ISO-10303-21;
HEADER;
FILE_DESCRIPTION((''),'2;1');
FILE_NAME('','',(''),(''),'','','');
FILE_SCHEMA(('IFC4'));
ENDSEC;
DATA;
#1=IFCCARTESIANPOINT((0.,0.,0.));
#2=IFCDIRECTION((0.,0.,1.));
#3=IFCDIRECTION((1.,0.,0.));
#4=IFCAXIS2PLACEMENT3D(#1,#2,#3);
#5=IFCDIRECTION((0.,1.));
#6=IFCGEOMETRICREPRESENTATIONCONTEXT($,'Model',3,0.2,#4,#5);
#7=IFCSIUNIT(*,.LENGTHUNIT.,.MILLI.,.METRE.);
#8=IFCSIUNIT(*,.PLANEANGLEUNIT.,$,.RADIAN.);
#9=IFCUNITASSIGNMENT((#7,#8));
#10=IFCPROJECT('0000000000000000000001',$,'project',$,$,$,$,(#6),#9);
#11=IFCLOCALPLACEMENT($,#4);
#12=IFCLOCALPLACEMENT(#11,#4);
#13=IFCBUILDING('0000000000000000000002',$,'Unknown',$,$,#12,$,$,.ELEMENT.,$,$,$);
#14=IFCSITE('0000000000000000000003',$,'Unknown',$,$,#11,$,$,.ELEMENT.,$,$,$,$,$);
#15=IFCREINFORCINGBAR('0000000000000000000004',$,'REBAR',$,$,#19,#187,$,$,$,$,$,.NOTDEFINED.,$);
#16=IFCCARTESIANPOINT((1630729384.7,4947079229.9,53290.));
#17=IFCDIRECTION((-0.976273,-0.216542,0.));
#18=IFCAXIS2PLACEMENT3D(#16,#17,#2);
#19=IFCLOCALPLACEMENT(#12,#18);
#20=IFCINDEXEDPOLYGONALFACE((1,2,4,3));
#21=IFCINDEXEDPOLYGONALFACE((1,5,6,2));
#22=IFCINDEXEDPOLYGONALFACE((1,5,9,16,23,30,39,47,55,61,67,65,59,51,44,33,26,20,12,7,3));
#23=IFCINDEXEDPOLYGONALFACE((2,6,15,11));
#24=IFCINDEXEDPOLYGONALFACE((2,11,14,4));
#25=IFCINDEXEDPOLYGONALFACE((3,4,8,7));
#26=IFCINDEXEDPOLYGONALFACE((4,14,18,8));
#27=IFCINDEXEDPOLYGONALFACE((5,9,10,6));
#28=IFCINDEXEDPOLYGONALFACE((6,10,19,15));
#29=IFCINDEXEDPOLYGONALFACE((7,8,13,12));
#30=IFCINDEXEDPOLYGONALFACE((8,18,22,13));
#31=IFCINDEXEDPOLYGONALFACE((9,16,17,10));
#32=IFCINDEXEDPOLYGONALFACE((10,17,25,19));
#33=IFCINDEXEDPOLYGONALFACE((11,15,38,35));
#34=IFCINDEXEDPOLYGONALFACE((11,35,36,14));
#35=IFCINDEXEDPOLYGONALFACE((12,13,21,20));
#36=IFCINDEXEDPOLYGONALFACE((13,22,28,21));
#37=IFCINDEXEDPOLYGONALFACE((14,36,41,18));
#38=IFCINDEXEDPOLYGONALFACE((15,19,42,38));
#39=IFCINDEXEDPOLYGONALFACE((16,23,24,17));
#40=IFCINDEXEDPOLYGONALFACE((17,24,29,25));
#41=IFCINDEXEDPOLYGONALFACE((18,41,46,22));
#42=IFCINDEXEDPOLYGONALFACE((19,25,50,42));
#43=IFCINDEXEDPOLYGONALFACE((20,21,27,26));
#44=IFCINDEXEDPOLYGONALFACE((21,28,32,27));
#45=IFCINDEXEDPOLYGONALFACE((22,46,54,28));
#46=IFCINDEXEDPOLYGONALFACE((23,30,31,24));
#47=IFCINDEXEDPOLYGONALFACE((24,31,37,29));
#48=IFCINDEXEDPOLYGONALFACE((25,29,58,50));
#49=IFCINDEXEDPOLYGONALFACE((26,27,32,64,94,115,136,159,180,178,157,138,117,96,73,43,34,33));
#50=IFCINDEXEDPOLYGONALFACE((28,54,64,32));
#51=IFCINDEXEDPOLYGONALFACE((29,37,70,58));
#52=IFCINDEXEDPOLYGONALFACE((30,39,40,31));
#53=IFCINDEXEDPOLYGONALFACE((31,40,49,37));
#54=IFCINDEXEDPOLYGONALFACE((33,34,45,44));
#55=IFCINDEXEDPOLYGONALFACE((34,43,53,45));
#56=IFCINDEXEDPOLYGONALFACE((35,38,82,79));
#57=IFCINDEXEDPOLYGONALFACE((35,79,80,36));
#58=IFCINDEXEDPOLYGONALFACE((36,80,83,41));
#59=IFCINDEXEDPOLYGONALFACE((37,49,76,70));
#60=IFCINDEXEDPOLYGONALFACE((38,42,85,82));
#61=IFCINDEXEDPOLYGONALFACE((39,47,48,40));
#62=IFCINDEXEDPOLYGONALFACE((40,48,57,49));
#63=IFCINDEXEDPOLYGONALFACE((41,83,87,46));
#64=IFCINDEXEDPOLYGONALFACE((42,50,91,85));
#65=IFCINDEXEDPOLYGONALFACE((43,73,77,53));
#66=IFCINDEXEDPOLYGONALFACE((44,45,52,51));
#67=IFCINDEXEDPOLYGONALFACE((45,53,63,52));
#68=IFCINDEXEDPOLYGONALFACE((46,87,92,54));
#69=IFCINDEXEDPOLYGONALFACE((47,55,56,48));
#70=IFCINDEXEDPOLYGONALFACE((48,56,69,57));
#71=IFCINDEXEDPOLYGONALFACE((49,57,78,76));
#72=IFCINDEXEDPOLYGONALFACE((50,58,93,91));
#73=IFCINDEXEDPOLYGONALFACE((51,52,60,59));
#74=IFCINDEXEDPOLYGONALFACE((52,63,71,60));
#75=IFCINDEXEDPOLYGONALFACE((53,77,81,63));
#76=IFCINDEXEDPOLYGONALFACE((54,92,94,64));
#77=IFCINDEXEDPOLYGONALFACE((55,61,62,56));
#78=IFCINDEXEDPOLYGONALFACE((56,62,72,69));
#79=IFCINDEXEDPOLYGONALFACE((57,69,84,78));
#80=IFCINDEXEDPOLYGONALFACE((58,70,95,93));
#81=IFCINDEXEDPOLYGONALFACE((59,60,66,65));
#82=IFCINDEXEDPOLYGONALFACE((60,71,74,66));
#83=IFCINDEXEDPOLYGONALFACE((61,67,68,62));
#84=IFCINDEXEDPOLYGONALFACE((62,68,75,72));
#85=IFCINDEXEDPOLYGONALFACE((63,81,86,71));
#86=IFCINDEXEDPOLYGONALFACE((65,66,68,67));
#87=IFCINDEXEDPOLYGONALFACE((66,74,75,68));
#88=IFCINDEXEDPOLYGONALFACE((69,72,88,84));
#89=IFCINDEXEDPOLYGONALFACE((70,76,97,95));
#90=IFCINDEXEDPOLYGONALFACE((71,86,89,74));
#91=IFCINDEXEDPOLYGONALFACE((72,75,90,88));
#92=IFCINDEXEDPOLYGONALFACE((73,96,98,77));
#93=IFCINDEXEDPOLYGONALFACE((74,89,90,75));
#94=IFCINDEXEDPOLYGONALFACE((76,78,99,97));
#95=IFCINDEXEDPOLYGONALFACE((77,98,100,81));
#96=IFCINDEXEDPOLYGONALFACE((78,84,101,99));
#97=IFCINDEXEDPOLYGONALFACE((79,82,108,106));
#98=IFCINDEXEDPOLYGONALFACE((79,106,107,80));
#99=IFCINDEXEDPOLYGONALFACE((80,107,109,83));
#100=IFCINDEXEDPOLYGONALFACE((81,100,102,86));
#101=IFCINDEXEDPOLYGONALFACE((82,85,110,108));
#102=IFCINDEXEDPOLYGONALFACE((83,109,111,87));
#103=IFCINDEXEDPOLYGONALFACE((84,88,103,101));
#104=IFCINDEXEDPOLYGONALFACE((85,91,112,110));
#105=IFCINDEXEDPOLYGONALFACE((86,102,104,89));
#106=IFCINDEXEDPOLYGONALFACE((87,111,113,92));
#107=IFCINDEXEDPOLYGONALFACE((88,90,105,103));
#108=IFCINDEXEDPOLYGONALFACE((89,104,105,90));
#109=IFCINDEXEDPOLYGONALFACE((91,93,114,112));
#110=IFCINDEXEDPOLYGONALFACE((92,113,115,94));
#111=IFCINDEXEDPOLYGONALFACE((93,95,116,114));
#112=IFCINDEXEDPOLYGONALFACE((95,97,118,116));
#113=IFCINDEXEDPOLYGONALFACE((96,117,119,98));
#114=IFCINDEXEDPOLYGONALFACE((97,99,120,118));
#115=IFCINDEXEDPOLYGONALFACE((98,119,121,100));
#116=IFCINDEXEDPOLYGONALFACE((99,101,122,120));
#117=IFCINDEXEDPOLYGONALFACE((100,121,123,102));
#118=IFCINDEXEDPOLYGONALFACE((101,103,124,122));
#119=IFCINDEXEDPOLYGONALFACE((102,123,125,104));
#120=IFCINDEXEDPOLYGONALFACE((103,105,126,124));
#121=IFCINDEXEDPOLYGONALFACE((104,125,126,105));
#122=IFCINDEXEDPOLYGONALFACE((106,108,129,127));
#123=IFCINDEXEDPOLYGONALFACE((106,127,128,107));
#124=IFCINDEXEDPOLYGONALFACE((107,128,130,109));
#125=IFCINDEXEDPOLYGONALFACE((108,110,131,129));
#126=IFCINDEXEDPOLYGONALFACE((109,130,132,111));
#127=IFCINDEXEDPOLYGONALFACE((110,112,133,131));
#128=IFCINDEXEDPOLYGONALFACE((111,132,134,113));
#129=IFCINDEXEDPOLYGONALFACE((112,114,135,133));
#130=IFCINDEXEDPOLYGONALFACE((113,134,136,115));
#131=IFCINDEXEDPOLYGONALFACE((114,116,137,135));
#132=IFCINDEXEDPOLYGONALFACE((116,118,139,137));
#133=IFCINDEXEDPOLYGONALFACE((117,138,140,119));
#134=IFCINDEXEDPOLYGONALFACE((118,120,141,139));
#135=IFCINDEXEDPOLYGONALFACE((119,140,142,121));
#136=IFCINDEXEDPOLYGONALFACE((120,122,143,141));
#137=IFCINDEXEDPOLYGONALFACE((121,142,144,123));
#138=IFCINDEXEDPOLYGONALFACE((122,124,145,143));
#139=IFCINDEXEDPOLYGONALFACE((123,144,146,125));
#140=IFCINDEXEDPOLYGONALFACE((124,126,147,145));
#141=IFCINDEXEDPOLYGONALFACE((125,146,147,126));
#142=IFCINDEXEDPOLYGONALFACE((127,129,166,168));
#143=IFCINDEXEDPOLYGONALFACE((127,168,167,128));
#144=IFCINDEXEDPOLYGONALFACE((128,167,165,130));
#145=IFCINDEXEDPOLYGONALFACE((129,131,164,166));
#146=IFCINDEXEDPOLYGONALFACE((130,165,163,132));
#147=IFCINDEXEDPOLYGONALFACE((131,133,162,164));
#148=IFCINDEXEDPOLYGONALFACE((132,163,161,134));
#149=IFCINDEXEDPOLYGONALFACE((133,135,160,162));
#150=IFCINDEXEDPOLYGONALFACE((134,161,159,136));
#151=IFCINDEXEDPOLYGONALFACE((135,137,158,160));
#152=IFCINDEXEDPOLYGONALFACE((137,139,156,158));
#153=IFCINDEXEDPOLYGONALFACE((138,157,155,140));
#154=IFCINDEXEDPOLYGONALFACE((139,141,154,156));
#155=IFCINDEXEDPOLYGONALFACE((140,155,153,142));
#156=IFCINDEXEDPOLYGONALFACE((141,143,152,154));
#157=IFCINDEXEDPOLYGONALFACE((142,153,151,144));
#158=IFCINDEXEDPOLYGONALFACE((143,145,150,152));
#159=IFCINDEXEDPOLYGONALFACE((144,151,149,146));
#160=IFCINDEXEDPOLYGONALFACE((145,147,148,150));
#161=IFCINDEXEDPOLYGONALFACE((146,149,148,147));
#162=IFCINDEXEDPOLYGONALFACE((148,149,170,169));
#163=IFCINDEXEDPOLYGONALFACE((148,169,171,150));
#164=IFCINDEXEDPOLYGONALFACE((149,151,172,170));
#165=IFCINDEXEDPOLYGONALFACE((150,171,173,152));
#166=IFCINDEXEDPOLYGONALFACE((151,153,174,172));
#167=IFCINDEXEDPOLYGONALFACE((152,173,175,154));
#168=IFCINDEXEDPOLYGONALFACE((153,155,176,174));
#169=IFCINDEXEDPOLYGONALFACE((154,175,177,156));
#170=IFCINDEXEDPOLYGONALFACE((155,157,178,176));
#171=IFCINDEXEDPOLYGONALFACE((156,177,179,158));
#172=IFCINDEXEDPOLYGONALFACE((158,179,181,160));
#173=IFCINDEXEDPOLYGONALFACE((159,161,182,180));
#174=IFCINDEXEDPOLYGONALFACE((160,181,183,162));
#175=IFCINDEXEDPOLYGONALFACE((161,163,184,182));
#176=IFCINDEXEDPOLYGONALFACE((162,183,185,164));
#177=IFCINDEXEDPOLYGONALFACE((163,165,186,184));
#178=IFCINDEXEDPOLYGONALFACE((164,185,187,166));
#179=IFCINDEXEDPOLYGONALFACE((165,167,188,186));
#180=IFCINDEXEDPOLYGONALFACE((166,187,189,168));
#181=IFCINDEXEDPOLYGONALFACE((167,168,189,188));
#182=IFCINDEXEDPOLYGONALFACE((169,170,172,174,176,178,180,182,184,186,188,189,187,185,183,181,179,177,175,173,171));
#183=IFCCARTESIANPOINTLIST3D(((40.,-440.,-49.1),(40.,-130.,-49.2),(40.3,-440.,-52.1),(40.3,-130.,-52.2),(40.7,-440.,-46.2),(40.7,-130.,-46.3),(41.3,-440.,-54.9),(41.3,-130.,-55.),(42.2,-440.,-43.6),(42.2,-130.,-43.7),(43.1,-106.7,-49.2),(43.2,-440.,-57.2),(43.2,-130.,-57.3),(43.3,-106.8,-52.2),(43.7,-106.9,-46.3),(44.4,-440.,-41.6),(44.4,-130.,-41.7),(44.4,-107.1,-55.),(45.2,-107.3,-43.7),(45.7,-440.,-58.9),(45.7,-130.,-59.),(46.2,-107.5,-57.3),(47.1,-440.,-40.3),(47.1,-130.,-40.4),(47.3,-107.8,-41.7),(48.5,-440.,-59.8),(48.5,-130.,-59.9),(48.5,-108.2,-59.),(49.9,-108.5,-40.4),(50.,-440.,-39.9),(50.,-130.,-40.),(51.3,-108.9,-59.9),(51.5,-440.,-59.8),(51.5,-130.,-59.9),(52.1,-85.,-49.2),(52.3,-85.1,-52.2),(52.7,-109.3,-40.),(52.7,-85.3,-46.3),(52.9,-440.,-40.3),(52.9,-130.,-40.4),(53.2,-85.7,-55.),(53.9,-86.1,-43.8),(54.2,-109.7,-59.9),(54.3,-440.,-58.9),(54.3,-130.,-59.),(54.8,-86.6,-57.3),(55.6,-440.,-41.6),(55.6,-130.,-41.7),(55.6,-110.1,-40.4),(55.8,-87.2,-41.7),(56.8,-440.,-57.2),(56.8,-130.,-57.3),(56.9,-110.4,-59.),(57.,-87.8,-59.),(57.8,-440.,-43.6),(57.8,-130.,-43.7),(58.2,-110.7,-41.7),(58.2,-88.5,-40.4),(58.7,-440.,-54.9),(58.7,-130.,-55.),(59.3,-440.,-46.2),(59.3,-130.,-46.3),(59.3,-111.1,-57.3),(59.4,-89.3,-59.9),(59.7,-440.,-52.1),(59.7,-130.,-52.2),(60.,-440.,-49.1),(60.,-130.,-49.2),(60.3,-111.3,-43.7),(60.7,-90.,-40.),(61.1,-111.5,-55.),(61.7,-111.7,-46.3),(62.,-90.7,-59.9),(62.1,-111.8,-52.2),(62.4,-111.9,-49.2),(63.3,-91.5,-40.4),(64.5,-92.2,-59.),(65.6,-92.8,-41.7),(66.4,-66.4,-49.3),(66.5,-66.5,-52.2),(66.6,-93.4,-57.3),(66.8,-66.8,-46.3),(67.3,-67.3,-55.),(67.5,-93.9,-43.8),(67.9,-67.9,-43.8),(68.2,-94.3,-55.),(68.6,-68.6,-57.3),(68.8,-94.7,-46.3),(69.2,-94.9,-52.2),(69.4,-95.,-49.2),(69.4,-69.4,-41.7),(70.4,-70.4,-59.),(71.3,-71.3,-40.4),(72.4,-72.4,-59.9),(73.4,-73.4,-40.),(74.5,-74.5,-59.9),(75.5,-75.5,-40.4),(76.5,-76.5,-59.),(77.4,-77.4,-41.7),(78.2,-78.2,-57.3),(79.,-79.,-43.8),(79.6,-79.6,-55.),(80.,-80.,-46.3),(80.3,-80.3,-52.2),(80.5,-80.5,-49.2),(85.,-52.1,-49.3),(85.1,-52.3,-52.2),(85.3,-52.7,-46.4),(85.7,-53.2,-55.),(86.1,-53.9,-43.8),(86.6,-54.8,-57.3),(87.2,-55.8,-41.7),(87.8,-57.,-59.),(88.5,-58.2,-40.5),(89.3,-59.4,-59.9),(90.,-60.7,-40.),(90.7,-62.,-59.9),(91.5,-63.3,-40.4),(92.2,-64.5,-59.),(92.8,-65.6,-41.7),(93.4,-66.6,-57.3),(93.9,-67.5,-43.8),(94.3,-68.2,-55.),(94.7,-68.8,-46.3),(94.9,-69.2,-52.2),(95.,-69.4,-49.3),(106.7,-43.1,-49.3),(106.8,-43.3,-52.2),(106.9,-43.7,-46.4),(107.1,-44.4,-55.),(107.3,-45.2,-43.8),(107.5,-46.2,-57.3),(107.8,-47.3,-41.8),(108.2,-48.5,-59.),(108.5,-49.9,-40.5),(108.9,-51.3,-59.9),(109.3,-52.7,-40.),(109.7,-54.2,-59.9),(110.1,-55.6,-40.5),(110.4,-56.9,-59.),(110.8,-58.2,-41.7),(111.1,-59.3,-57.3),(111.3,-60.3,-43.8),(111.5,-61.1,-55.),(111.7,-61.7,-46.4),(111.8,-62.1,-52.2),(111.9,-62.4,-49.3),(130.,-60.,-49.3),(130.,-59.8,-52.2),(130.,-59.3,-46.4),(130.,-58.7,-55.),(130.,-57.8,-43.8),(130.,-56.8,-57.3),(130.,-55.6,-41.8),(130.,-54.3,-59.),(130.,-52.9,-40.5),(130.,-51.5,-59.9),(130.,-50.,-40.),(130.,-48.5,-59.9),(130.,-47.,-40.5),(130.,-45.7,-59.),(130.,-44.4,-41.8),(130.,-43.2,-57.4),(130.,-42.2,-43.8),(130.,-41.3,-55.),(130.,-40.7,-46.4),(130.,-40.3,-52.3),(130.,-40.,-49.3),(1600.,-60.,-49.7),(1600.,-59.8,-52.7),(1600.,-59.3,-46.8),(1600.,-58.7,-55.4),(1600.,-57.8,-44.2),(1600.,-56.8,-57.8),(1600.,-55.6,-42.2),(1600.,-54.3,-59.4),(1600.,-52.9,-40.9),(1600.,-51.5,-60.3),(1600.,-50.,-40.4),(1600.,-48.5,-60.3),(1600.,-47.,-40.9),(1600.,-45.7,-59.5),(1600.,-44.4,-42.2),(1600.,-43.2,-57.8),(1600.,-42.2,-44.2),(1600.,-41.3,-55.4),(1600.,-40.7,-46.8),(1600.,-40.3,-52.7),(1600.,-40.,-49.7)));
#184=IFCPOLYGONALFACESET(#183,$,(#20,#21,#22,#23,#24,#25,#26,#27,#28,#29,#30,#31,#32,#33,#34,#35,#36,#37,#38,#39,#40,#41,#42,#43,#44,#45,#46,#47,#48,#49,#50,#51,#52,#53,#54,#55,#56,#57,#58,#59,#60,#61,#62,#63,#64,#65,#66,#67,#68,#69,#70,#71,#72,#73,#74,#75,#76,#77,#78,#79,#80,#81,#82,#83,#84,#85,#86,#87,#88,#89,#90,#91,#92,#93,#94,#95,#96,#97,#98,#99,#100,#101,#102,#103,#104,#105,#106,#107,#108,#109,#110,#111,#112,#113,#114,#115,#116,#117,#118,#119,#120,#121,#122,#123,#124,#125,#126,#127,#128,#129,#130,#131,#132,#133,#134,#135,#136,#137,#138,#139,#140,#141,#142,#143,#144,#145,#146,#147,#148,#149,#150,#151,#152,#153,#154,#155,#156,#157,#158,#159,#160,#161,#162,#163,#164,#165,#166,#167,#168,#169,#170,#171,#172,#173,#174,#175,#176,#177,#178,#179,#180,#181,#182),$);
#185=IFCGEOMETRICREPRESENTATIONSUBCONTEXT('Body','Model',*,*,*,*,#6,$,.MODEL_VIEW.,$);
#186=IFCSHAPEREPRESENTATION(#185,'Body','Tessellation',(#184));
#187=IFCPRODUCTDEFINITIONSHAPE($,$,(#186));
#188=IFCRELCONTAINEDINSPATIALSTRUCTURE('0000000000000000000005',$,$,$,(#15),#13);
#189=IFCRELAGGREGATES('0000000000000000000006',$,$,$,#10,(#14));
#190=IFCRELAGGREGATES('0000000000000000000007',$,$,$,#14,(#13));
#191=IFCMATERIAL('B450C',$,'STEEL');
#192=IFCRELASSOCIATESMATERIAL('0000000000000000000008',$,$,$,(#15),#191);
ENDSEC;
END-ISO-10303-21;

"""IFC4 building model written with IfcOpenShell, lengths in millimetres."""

from ifc_helpers import new_model, entity, si_unit, direction, frame, origin_with_axes, place, context, subcontext, project, spatial, material, element, save


model = new_model("IFC4")

# Units and contexts
model_context = context("Model", 3, precision=0.2, world=origin_with_axes(), true_north=direction((0.0, 1.0)))
body_context = subcontext(model_context, "Body", "Model", "MODEL_VIEW")
ifc_project = project(units=[si_unit("LENGTHUNIT", "METRE", prefix="MILLI"), si_unit("PLANEANGLEUNIT", "RADIAN")], contexts=[model_context])

# Site, building
site_placement = place(None, origin_with_axes())
site = spatial("IfcSite", under=ifc_project, at=site_placement, Name="Unknown", CompositionType="ELEMENT")
building_placement = place(site_placement, origin_with_axes())
building = spatial("IfcBuilding", under=site, at=building_placement, Name="Unknown", CompositionType="ELEMENT")

# Reinforcing bar
ifc_material = material(Name="B450C", Category="STEEL")
reinforcing_bar_1_placement = place(building_placement, frame((1630729384.7, 4947079229.9, 53290.0), z_axis=(-0.976273, -0.216542, 0.0), x_axis=(0.0, 0.0, 1.0)))
element("IfcReinforcingBar", 1, at=reinforcing_bar_1_placement, inside=building, material=ifc_material, Name="REBAR", PredefinedType="NOTDEFINED", context=body_context, shape_type="AdvancedSweptSolid", body=[
    entity("IfcSweptDiskSolid", entity("IfcIndexedPolyCurve", entity("IfcCartesianPointList3D", [[50.0, -440.0, -49.9], [50.0, -130.0, -50.0], [73.4, -73.4, -50.0], [130.0, -50.0, -50.0], [1600.0, -50.0, -50.4]]), [entity("IfcLineIndex", [1, 2]), entity("IfcArcIndex", [2, 3, 4]), entity("IfcLineIndex", [4, 5])]), 10.0),
])

save(model, "model.ifc")
